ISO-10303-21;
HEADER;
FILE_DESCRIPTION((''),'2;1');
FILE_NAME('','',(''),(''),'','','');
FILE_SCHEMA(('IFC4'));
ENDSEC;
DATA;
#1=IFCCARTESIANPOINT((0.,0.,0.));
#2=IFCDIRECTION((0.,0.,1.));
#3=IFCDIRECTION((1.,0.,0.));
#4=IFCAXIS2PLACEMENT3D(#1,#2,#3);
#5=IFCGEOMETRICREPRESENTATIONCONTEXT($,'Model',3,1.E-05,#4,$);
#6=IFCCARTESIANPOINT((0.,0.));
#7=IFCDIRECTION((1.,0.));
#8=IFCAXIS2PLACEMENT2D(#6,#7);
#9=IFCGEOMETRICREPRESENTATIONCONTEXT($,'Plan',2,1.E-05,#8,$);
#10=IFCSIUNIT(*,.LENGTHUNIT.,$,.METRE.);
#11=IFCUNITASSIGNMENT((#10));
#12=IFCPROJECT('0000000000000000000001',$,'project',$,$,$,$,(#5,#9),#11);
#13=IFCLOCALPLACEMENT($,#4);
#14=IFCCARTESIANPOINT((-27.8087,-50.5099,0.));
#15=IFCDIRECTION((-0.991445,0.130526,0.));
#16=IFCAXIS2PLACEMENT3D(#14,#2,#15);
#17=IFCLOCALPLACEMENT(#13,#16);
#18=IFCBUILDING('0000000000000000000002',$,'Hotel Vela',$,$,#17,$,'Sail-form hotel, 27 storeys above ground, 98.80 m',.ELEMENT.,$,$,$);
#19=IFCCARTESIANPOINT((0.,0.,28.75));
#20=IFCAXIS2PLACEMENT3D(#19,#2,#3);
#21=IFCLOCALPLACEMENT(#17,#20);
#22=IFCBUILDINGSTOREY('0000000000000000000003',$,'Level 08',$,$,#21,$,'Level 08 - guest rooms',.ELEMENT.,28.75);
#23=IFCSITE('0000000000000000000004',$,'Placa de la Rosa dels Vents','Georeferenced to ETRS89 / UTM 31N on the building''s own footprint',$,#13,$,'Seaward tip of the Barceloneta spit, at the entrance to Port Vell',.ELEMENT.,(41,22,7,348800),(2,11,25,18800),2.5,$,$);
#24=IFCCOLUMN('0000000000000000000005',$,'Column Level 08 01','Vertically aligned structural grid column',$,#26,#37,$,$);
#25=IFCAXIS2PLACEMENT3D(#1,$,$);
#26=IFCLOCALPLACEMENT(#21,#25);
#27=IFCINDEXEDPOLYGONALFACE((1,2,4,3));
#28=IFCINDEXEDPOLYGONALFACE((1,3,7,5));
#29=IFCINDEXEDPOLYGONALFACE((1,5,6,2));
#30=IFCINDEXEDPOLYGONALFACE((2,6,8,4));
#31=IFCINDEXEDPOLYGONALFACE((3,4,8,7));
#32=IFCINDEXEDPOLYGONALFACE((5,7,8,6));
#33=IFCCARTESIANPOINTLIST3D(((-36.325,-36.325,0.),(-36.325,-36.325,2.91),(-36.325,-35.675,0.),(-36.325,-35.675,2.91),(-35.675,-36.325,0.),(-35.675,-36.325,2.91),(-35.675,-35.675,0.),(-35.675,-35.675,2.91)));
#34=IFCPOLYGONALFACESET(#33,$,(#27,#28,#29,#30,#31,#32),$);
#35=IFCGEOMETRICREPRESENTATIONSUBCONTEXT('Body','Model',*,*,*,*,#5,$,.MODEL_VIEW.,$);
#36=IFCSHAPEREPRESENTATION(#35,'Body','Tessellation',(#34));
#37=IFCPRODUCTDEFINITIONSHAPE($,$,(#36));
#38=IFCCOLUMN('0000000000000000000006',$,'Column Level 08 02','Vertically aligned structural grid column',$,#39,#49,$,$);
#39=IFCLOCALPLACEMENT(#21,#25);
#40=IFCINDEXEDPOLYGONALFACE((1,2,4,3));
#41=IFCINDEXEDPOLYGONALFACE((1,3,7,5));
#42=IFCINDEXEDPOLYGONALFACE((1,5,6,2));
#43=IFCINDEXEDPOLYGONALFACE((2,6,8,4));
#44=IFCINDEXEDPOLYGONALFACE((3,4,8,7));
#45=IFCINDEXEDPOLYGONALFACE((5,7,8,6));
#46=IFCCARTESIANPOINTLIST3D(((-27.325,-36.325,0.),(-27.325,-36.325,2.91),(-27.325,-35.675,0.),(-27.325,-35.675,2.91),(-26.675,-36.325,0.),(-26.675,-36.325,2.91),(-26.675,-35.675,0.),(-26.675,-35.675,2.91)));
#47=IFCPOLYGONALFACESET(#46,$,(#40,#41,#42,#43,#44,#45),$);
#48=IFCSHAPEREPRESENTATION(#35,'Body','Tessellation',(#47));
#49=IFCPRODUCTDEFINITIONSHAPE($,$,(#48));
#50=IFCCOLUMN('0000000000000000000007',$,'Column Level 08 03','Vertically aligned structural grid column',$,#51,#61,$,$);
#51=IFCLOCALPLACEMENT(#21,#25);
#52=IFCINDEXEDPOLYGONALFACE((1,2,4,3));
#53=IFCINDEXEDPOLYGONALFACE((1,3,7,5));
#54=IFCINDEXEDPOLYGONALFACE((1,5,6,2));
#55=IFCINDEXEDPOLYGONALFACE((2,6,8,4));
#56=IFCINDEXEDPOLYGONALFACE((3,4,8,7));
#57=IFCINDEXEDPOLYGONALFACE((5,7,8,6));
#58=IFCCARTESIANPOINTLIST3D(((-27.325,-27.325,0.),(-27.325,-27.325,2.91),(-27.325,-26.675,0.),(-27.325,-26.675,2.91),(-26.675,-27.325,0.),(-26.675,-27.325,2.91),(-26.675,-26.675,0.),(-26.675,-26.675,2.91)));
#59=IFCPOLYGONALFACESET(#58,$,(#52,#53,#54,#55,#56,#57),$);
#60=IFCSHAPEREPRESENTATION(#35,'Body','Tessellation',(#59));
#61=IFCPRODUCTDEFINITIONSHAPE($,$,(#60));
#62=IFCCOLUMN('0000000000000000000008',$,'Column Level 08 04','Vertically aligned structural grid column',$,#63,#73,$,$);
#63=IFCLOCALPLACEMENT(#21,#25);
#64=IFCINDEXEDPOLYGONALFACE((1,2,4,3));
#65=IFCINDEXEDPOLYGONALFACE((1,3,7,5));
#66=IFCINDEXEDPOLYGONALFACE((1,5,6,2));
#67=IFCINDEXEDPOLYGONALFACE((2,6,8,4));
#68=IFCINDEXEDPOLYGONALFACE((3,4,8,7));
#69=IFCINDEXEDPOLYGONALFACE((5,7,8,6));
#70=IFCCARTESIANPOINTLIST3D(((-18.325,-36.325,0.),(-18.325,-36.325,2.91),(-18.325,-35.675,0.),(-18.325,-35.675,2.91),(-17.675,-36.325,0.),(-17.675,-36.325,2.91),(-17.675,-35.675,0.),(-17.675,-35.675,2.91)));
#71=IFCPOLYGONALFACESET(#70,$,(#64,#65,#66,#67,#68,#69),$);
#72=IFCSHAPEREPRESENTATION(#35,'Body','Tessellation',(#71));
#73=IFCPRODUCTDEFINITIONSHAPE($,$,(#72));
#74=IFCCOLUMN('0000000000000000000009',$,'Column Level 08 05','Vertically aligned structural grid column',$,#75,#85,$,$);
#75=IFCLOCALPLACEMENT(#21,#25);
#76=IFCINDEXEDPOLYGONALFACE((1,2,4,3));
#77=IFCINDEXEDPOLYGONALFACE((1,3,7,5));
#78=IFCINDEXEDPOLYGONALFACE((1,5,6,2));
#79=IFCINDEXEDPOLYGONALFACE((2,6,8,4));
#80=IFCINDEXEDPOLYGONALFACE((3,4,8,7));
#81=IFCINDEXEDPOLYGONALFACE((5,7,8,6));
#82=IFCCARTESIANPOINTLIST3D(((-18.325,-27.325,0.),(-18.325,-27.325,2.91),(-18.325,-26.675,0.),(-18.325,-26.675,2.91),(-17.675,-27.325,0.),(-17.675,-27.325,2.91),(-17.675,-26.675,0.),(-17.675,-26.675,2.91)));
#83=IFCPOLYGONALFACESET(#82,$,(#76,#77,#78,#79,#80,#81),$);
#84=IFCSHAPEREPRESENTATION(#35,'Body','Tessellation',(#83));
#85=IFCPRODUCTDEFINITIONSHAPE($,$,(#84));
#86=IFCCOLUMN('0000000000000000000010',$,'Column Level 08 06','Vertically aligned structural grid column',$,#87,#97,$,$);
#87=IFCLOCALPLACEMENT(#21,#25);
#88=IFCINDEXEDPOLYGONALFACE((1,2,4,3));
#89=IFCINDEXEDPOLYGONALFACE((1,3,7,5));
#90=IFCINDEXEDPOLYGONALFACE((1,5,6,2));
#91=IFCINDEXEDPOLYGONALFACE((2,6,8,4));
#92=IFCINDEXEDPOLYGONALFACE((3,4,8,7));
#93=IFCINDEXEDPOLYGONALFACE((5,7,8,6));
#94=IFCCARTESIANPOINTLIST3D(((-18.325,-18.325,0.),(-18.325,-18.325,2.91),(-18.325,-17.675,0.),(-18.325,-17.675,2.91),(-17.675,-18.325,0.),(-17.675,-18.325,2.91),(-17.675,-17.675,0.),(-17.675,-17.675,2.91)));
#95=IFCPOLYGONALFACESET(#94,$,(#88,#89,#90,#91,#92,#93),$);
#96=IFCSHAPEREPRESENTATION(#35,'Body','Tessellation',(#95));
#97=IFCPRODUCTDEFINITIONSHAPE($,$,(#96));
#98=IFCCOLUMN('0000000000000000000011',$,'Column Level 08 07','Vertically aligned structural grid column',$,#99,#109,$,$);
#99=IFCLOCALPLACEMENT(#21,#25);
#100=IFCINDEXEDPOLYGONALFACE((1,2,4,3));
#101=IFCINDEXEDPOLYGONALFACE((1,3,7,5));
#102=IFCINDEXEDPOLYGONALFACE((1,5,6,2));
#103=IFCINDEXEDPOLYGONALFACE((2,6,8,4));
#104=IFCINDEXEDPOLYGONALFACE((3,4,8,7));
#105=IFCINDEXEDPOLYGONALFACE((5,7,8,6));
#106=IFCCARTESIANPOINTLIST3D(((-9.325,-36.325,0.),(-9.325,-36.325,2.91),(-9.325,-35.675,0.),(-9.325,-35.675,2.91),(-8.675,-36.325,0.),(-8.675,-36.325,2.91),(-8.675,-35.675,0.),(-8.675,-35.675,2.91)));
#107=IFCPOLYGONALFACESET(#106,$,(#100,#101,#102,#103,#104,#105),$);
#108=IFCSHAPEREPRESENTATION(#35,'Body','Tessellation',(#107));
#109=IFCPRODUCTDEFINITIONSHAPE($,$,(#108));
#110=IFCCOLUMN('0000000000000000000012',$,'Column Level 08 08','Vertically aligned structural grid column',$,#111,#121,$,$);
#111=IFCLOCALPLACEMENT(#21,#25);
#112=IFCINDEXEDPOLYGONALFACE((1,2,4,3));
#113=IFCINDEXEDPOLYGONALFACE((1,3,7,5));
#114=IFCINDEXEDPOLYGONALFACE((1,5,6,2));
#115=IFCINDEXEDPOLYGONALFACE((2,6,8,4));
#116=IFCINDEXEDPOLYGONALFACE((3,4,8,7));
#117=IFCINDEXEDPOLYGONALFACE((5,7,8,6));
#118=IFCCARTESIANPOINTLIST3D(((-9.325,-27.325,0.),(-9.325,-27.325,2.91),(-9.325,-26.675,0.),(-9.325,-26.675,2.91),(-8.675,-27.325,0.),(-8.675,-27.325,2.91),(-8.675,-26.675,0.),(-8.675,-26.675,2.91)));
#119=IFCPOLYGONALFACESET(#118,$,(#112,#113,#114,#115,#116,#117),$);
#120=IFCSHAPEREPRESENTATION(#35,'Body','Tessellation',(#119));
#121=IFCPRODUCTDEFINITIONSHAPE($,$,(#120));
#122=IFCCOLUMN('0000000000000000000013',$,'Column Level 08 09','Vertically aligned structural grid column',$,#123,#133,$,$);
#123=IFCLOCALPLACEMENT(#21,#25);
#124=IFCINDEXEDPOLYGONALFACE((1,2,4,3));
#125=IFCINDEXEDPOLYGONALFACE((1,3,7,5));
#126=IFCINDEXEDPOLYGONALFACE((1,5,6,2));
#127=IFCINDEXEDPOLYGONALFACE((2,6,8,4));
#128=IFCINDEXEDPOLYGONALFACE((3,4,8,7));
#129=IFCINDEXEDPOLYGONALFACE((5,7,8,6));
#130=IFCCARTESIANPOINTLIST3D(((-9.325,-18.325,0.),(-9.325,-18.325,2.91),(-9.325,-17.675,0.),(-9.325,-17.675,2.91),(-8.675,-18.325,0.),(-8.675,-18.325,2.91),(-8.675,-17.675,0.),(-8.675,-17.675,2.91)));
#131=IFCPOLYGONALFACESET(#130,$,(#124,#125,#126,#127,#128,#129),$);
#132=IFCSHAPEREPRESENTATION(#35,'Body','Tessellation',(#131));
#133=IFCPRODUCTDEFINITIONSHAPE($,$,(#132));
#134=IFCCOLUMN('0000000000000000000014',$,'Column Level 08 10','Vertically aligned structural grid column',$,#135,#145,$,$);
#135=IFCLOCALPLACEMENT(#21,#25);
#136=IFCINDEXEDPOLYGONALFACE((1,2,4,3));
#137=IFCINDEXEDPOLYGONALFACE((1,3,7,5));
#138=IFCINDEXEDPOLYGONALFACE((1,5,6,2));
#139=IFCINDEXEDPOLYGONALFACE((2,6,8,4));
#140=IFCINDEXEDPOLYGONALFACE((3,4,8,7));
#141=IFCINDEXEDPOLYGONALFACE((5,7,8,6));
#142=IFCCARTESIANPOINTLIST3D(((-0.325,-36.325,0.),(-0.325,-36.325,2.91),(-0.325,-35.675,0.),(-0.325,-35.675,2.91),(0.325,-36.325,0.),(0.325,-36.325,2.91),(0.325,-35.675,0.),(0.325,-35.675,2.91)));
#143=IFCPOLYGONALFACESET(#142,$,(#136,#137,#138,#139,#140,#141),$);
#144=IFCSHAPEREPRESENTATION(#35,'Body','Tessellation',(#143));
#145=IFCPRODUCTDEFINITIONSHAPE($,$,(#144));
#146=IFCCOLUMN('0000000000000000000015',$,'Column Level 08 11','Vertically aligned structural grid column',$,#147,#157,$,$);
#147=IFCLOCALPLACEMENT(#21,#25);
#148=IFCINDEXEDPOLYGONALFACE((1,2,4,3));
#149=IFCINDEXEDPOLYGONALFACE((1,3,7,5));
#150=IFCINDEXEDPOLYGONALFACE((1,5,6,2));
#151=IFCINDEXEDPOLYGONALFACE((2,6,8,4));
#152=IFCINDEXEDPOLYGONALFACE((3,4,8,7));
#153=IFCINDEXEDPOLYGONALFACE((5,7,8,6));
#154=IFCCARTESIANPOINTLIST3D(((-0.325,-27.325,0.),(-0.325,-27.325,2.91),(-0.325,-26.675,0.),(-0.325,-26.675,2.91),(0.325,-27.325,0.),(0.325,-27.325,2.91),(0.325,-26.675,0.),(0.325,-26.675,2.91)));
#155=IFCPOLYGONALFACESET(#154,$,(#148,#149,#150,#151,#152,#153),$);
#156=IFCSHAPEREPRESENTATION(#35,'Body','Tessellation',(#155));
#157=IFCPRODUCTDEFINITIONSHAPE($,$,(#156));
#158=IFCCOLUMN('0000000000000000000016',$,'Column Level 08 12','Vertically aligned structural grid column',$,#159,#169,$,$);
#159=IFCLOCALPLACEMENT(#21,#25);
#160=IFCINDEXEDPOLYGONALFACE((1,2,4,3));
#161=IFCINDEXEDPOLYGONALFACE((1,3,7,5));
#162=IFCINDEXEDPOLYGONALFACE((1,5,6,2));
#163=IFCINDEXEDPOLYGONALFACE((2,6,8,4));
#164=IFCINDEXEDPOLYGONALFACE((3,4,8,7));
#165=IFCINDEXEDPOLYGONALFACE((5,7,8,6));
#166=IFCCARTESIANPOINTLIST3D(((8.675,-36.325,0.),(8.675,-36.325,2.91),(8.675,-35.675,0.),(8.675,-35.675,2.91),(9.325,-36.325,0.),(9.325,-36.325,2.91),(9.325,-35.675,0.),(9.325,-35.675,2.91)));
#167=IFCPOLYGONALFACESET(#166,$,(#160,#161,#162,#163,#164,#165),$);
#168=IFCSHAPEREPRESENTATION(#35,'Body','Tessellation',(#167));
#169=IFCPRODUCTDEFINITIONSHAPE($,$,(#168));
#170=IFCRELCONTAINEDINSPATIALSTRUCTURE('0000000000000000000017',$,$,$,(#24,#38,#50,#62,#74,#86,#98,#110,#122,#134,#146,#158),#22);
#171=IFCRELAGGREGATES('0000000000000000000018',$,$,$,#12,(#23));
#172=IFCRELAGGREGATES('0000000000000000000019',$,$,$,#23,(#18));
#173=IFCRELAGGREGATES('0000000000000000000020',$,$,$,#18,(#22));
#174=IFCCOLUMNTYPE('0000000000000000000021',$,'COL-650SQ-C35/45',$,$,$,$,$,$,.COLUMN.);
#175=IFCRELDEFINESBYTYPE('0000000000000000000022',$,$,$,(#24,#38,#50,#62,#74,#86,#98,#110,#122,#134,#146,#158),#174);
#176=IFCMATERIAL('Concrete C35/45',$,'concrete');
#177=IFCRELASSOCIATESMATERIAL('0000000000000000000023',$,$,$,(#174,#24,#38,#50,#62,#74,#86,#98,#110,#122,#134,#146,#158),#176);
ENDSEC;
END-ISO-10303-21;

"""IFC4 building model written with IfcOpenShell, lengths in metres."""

from ifc_helpers import new_model, si_unit, frame, origin_with_axes, origin_2d_with_axis, place, context, subcontext, project, spatial, line, indexed_curve, rectangle, outline, extrude, material, material_profile, profile_set, profile_usage, type_object, element, save


model = new_model("IFC4")

# Units and contexts
model_context = context("Model", 3, precision=1e-05, world=origin_with_axes())
plan_context = context("Plan", 2, precision=1e-05, world=origin_2d_with_axis())
body_context = subcontext(model_context, "Body", "Model", "MODEL_VIEW")
ifc_project = project(units=[si_unit("LENGTHUNIT", "METRE")], contexts=[model_context, plan_context])

# Site, building, storey
site_placement = place(None, origin_with_axes())
site = spatial("IfcSite", under=ifc_project, at=site_placement, Name="Placa de la Rosa dels Vents", Description="Georeferenced to ETRS89 / UTM 31N on the building's own footprint", LongName="Seaward tip of the Barceloneta spit, at the entrance to Port Vell", CompositionType="ELEMENT", RefLatitude=(41, 22, 7, 348800), RefLongitude=(2, 11, 25, 18800), RefElevation=2.5)
building_placement = place(site_placement, frame((-27.8087, -50.5099, 0.0), z_axis=(0.0, 0.0, 1.0), x_axis=(-0.991445, 0.130526, 0.0)))
building = spatial("IfcBuilding", under=site, at=building_placement, Name="Hotel Vela", LongName="Sail-form hotel, 27 storeys above ground, 98.80 m", CompositionType="ELEMENT")
storey_placement = place(building_placement, frame((0.0, 0.0, 28.75), z_axis=(0.0, 0.0, 1.0), x_axis=(1.0, 0.0, 0.0)))
storey = spatial("IfcBuildingStorey", under=building, at=storey_placement, Name="Level 08", LongName="Level 08 - guest rooms", CompositionType="ELEMENT", Elevation=28.75)

# Columns
ifc_material = material(Name="Concrete C35/45", Category="concrete")
ifc_material_profile = material_profile(ifc_material, rectangle(XDim=0.65, YDim=0.65))
ifc_profile_set = profile_set([ifc_material_profile], Name="COL-650SQ-C35/45")
ifc_profile_usage_1 = profile_usage(ifc_profile_set)
column_type = type_object("IfcColumnType", Name="COL-650SQ-C35/45", PredefinedType="COLUMN", material=ifc_profile_set)
column_1_placement = place(storey_placement, frame((-36.325, -36.325, 0.0), z_axis=(0.0, 0.0, 1.0), x_axis=(1.0, 0.0, 0.0)))
element("IfcColumn", 1, at=column_1_placement, inside=storey, type_object=column_type, material=ifc_profile_usage_1, Name="Column Level 08 01", Description="Vertically aligned structural grid column", context=body_context, shape_type="SweptSolid", body=[
    extrude(outline(indexed_curve([(0.0, 0.0), (0.65, 0.0), (0.65, 0.65), (0.0, 0.65)], segments=[line(1, 2, 3, 4, 1)])), origin_with_axes(), (0.0, 0.0, 1.0), 2.91),
])
ifc_profile_usage_2 = profile_usage(ifc_profile_set)
column_2_placement = place(storey_placement, frame((-27.325, -36.325, 0.0), z_axis=(0.0, 0.0, 1.0), x_axis=(1.0, 0.0, 0.0)))
element("IfcColumn", 2, at=column_2_placement, inside=storey, type_object=column_type, material=ifc_profile_usage_2, Name="Column Level 08 02", Description="Vertically aligned structural grid column", context=body_context, shape_type="SweptSolid", body=[
    extrude(outline(indexed_curve([(0.0, 0.0), (0.65, 0.0), (0.65, 0.65), (0.0, 0.65)], segments=[line(1, 2, 3, 4, 1)])), origin_with_axes(), (0.0, 0.0, 1.0), 2.91),
])
ifc_profile_usage_3 = profile_usage(ifc_profile_set)
column_3_placement = place(storey_placement, frame((-27.325, -27.325, 0.0), z_axis=(0.0, 0.0, 1.0), x_axis=(1.0, 0.0, 0.0)))
element("IfcColumn", 3, at=column_3_placement, inside=storey, type_object=column_type, material=ifc_profile_usage_3, Name="Column Level 08 03", Description="Vertically aligned structural grid column", context=body_context, shape_type="SweptSolid", body=[
    extrude(outline(indexed_curve([(0.0, 0.0), (0.65, 0.0), (0.65, 0.65), (0.0, 0.65)], segments=[line(1, 2, 3, 4, 1)])), origin_with_axes(), (0.0, 0.0, 1.0), 2.91),
])
ifc_profile_usage_4 = profile_usage(ifc_profile_set)
column_4_placement = place(storey_placement, frame((-18.325, -36.325, 0.0), z_axis=(0.0, 0.0, 1.0), x_axis=(1.0, 0.0, 0.0)))
element("IfcColumn", 4, at=column_4_placement, inside=storey, type_object=column_type, material=ifc_profile_usage_4, Name="Column Level 08 04", Description="Vertically aligned structural grid column", context=body_context, shape_type="SweptSolid", body=[
    extrude(outline(indexed_curve([(0.0, 0.0), (0.65, 0.0), (0.65, 0.65), (0.0, 0.65)], segments=[line(1, 2, 3, 4, 1)])), origin_with_axes(), (0.0, 0.0, 1.0), 2.91),
])
ifc_profile_usage_5 = profile_usage(ifc_profile_set)
column_5_placement = place(storey_placement, frame((-18.325, -27.325, 0.0), z_axis=(0.0, 0.0, 1.0), x_axis=(1.0, 0.0, 0.0)))
element("IfcColumn", 5, at=column_5_placement, inside=storey, type_object=column_type, material=ifc_profile_usage_5, Name="Column Level 08 05", Description="Vertically aligned structural grid column", context=body_context, shape_type="SweptSolid", body=[
    extrude(outline(indexed_curve([(0.0, 0.0), (0.65, 0.0), (0.65, 0.65), (0.0, 0.65)], segments=[line(1, 2, 3, 4, 1)])), origin_with_axes(), (0.0, 0.0, 1.0), 2.91),
])
ifc_profile_usage_6 = profile_usage(ifc_profile_set)
column_6_placement = place(storey_placement, frame((-18.325, -18.325, 0.0), z_axis=(0.0, 0.0, 1.0), x_axis=(1.0, 0.0, 0.0)))
element("IfcColumn", 6, at=column_6_placement, inside=storey, type_object=column_type, material=ifc_profile_usage_6, Name="Column Level 08 06", Description="Vertically aligned structural grid column", context=body_context, shape_type="SweptSolid", body=[
    extrude(outline(indexed_curve([(0.0, 0.0), (0.65, 0.0), (0.65, 0.65), (0.0, 0.65)], segments=[line(1, 2, 3, 4, 1)])), origin_with_axes(), (0.0, 0.0, 1.0), 2.91),
])
ifc_profile_usage_7 = profile_usage(ifc_profile_set)
column_7_placement = place(storey_placement, frame((-9.325, -36.325, 0.0), z_axis=(0.0, 0.0, 1.0), x_axis=(1.0, 0.0, 0.0)))
element("IfcColumn", 7, at=column_7_placement, inside=storey, type_object=column_type, material=ifc_profile_usage_7, Name="Column Level 08 07", Description="Vertically aligned structural grid column", context=body_context, shape_type="SweptSolid", body=[
    extrude(outline(indexed_curve([(0.0, 0.0), (0.65, 0.0), (0.65, 0.65), (0.0, 0.65)], segments=[line(1, 2, 3, 4, 1)])), origin_with_axes(), (0.0, 0.0, 1.0), 2.91),
])
ifc_profile_usage_8 = profile_usage(ifc_profile_set)
column_8_placement = place(storey_placement, frame((-9.325, -27.325, 0.0), z_axis=(0.0, 0.0, 1.0), x_axis=(1.0, 0.0, 0.0)))
element("IfcColumn", 8, at=column_8_placement, inside=storey, type_object=column_type, material=ifc_profile_usage_8, Name="Column Level 08 08", Description="Vertically aligned structural grid column", context=body_context, shape_type="SweptSolid", body=[
    extrude(outline(indexed_curve([(0.0, 0.0), (0.65, 0.0), (0.65, 0.65), (0.0, 0.65)], segments=[line(1, 2, 3, 4, 1)])), origin_with_axes(), (0.0, 0.0, 1.0), 2.91),
])
ifc_profile_usage_9 = profile_usage(ifc_profile_set)
column_9_placement = place(storey_placement, frame((-9.325, -18.325, 0.0), z_axis=(0.0, 0.0, 1.0), x_axis=(1.0, 0.0, 0.0)))
element("IfcColumn", 9, at=column_9_placement, inside=storey, type_object=column_type, material=ifc_profile_usage_9, Name="Column Level 08 09", Description="Vertically aligned structural grid column", context=body_context, shape_type="SweptSolid", body=[
    extrude(outline(indexed_curve([(0.0, 0.0), (0.65, 0.0), (0.65, 0.65), (0.0, 0.65)], segments=[line(1, 2, 3, 4, 1)])), origin_with_axes(), (0.0, 0.0, 1.0), 2.91),
])
ifc_profile_usage_10 = profile_usage(ifc_profile_set)
column_10_placement = place(storey_placement, frame((-0.325, -36.325, 0.0), z_axis=(0.0, 0.0, 1.0), x_axis=(1.0, 0.0, 0.0)))
element("IfcColumn", 10, at=column_10_placement, inside=storey, type_object=column_type, material=ifc_profile_usage_10, Name="Column Level 08 10", Description="Vertically aligned structural grid column", context=body_context, shape_type="SweptSolid", body=[
    extrude(outline(indexed_curve([(0.0, 0.0), (0.65, 0.0), (0.65, 0.65), (0.0, 0.65)], segments=[line(1, 2, 3, 4, 1)])), origin_with_axes(), (0.0, 0.0, 1.0), 2.91),
])
ifc_profile_usage_11 = profile_usage(ifc_profile_set)
column_11_placement = place(storey_placement, frame((-0.325, -27.325, 0.0), z_axis=(0.0, 0.0, 1.0), x_axis=(1.0, 0.0, 0.0)))
element("IfcColumn", 11, at=column_11_placement, inside=storey, type_object=column_type, material=ifc_profile_usage_11, Name="Column Level 08 11", Description="Vertically aligned structural grid column", context=body_context, shape_type="SweptSolid", body=[
    extrude(outline(indexed_curve([(0.0, 0.0), (0.65, 0.0), (0.65, 0.65), (0.0, 0.65)], segments=[line(1, 2, 3, 4, 1)])), origin_with_axes(), (0.0, 0.0, 1.0), 2.91),
])
ifc_profile_usage_12 = profile_usage(ifc_profile_set)
column_12_placement = place(storey_placement, frame((8.675, -36.325, 0.0), z_axis=(0.0, 0.0, 1.0), x_axis=(1.0, 0.0, 0.0)))
element("IfcColumn", 12, at=column_12_placement, inside=storey, type_object=column_type, material=ifc_profile_usage_12, Name="Column Level 08 12", Description="Vertically aligned structural grid column", context=body_context, shape_type="SweptSolid", body=[
    extrude(outline(indexed_curve([(0.0, 0.0), (0.65, 0.0), (0.65, 0.65), (0.0, 0.65)], segments=[line(1, 2, 3, 4, 1)])), origin_with_axes(), (0.0, 0.0, 1.0), 2.91),
])

save(model, "model.ifc")
